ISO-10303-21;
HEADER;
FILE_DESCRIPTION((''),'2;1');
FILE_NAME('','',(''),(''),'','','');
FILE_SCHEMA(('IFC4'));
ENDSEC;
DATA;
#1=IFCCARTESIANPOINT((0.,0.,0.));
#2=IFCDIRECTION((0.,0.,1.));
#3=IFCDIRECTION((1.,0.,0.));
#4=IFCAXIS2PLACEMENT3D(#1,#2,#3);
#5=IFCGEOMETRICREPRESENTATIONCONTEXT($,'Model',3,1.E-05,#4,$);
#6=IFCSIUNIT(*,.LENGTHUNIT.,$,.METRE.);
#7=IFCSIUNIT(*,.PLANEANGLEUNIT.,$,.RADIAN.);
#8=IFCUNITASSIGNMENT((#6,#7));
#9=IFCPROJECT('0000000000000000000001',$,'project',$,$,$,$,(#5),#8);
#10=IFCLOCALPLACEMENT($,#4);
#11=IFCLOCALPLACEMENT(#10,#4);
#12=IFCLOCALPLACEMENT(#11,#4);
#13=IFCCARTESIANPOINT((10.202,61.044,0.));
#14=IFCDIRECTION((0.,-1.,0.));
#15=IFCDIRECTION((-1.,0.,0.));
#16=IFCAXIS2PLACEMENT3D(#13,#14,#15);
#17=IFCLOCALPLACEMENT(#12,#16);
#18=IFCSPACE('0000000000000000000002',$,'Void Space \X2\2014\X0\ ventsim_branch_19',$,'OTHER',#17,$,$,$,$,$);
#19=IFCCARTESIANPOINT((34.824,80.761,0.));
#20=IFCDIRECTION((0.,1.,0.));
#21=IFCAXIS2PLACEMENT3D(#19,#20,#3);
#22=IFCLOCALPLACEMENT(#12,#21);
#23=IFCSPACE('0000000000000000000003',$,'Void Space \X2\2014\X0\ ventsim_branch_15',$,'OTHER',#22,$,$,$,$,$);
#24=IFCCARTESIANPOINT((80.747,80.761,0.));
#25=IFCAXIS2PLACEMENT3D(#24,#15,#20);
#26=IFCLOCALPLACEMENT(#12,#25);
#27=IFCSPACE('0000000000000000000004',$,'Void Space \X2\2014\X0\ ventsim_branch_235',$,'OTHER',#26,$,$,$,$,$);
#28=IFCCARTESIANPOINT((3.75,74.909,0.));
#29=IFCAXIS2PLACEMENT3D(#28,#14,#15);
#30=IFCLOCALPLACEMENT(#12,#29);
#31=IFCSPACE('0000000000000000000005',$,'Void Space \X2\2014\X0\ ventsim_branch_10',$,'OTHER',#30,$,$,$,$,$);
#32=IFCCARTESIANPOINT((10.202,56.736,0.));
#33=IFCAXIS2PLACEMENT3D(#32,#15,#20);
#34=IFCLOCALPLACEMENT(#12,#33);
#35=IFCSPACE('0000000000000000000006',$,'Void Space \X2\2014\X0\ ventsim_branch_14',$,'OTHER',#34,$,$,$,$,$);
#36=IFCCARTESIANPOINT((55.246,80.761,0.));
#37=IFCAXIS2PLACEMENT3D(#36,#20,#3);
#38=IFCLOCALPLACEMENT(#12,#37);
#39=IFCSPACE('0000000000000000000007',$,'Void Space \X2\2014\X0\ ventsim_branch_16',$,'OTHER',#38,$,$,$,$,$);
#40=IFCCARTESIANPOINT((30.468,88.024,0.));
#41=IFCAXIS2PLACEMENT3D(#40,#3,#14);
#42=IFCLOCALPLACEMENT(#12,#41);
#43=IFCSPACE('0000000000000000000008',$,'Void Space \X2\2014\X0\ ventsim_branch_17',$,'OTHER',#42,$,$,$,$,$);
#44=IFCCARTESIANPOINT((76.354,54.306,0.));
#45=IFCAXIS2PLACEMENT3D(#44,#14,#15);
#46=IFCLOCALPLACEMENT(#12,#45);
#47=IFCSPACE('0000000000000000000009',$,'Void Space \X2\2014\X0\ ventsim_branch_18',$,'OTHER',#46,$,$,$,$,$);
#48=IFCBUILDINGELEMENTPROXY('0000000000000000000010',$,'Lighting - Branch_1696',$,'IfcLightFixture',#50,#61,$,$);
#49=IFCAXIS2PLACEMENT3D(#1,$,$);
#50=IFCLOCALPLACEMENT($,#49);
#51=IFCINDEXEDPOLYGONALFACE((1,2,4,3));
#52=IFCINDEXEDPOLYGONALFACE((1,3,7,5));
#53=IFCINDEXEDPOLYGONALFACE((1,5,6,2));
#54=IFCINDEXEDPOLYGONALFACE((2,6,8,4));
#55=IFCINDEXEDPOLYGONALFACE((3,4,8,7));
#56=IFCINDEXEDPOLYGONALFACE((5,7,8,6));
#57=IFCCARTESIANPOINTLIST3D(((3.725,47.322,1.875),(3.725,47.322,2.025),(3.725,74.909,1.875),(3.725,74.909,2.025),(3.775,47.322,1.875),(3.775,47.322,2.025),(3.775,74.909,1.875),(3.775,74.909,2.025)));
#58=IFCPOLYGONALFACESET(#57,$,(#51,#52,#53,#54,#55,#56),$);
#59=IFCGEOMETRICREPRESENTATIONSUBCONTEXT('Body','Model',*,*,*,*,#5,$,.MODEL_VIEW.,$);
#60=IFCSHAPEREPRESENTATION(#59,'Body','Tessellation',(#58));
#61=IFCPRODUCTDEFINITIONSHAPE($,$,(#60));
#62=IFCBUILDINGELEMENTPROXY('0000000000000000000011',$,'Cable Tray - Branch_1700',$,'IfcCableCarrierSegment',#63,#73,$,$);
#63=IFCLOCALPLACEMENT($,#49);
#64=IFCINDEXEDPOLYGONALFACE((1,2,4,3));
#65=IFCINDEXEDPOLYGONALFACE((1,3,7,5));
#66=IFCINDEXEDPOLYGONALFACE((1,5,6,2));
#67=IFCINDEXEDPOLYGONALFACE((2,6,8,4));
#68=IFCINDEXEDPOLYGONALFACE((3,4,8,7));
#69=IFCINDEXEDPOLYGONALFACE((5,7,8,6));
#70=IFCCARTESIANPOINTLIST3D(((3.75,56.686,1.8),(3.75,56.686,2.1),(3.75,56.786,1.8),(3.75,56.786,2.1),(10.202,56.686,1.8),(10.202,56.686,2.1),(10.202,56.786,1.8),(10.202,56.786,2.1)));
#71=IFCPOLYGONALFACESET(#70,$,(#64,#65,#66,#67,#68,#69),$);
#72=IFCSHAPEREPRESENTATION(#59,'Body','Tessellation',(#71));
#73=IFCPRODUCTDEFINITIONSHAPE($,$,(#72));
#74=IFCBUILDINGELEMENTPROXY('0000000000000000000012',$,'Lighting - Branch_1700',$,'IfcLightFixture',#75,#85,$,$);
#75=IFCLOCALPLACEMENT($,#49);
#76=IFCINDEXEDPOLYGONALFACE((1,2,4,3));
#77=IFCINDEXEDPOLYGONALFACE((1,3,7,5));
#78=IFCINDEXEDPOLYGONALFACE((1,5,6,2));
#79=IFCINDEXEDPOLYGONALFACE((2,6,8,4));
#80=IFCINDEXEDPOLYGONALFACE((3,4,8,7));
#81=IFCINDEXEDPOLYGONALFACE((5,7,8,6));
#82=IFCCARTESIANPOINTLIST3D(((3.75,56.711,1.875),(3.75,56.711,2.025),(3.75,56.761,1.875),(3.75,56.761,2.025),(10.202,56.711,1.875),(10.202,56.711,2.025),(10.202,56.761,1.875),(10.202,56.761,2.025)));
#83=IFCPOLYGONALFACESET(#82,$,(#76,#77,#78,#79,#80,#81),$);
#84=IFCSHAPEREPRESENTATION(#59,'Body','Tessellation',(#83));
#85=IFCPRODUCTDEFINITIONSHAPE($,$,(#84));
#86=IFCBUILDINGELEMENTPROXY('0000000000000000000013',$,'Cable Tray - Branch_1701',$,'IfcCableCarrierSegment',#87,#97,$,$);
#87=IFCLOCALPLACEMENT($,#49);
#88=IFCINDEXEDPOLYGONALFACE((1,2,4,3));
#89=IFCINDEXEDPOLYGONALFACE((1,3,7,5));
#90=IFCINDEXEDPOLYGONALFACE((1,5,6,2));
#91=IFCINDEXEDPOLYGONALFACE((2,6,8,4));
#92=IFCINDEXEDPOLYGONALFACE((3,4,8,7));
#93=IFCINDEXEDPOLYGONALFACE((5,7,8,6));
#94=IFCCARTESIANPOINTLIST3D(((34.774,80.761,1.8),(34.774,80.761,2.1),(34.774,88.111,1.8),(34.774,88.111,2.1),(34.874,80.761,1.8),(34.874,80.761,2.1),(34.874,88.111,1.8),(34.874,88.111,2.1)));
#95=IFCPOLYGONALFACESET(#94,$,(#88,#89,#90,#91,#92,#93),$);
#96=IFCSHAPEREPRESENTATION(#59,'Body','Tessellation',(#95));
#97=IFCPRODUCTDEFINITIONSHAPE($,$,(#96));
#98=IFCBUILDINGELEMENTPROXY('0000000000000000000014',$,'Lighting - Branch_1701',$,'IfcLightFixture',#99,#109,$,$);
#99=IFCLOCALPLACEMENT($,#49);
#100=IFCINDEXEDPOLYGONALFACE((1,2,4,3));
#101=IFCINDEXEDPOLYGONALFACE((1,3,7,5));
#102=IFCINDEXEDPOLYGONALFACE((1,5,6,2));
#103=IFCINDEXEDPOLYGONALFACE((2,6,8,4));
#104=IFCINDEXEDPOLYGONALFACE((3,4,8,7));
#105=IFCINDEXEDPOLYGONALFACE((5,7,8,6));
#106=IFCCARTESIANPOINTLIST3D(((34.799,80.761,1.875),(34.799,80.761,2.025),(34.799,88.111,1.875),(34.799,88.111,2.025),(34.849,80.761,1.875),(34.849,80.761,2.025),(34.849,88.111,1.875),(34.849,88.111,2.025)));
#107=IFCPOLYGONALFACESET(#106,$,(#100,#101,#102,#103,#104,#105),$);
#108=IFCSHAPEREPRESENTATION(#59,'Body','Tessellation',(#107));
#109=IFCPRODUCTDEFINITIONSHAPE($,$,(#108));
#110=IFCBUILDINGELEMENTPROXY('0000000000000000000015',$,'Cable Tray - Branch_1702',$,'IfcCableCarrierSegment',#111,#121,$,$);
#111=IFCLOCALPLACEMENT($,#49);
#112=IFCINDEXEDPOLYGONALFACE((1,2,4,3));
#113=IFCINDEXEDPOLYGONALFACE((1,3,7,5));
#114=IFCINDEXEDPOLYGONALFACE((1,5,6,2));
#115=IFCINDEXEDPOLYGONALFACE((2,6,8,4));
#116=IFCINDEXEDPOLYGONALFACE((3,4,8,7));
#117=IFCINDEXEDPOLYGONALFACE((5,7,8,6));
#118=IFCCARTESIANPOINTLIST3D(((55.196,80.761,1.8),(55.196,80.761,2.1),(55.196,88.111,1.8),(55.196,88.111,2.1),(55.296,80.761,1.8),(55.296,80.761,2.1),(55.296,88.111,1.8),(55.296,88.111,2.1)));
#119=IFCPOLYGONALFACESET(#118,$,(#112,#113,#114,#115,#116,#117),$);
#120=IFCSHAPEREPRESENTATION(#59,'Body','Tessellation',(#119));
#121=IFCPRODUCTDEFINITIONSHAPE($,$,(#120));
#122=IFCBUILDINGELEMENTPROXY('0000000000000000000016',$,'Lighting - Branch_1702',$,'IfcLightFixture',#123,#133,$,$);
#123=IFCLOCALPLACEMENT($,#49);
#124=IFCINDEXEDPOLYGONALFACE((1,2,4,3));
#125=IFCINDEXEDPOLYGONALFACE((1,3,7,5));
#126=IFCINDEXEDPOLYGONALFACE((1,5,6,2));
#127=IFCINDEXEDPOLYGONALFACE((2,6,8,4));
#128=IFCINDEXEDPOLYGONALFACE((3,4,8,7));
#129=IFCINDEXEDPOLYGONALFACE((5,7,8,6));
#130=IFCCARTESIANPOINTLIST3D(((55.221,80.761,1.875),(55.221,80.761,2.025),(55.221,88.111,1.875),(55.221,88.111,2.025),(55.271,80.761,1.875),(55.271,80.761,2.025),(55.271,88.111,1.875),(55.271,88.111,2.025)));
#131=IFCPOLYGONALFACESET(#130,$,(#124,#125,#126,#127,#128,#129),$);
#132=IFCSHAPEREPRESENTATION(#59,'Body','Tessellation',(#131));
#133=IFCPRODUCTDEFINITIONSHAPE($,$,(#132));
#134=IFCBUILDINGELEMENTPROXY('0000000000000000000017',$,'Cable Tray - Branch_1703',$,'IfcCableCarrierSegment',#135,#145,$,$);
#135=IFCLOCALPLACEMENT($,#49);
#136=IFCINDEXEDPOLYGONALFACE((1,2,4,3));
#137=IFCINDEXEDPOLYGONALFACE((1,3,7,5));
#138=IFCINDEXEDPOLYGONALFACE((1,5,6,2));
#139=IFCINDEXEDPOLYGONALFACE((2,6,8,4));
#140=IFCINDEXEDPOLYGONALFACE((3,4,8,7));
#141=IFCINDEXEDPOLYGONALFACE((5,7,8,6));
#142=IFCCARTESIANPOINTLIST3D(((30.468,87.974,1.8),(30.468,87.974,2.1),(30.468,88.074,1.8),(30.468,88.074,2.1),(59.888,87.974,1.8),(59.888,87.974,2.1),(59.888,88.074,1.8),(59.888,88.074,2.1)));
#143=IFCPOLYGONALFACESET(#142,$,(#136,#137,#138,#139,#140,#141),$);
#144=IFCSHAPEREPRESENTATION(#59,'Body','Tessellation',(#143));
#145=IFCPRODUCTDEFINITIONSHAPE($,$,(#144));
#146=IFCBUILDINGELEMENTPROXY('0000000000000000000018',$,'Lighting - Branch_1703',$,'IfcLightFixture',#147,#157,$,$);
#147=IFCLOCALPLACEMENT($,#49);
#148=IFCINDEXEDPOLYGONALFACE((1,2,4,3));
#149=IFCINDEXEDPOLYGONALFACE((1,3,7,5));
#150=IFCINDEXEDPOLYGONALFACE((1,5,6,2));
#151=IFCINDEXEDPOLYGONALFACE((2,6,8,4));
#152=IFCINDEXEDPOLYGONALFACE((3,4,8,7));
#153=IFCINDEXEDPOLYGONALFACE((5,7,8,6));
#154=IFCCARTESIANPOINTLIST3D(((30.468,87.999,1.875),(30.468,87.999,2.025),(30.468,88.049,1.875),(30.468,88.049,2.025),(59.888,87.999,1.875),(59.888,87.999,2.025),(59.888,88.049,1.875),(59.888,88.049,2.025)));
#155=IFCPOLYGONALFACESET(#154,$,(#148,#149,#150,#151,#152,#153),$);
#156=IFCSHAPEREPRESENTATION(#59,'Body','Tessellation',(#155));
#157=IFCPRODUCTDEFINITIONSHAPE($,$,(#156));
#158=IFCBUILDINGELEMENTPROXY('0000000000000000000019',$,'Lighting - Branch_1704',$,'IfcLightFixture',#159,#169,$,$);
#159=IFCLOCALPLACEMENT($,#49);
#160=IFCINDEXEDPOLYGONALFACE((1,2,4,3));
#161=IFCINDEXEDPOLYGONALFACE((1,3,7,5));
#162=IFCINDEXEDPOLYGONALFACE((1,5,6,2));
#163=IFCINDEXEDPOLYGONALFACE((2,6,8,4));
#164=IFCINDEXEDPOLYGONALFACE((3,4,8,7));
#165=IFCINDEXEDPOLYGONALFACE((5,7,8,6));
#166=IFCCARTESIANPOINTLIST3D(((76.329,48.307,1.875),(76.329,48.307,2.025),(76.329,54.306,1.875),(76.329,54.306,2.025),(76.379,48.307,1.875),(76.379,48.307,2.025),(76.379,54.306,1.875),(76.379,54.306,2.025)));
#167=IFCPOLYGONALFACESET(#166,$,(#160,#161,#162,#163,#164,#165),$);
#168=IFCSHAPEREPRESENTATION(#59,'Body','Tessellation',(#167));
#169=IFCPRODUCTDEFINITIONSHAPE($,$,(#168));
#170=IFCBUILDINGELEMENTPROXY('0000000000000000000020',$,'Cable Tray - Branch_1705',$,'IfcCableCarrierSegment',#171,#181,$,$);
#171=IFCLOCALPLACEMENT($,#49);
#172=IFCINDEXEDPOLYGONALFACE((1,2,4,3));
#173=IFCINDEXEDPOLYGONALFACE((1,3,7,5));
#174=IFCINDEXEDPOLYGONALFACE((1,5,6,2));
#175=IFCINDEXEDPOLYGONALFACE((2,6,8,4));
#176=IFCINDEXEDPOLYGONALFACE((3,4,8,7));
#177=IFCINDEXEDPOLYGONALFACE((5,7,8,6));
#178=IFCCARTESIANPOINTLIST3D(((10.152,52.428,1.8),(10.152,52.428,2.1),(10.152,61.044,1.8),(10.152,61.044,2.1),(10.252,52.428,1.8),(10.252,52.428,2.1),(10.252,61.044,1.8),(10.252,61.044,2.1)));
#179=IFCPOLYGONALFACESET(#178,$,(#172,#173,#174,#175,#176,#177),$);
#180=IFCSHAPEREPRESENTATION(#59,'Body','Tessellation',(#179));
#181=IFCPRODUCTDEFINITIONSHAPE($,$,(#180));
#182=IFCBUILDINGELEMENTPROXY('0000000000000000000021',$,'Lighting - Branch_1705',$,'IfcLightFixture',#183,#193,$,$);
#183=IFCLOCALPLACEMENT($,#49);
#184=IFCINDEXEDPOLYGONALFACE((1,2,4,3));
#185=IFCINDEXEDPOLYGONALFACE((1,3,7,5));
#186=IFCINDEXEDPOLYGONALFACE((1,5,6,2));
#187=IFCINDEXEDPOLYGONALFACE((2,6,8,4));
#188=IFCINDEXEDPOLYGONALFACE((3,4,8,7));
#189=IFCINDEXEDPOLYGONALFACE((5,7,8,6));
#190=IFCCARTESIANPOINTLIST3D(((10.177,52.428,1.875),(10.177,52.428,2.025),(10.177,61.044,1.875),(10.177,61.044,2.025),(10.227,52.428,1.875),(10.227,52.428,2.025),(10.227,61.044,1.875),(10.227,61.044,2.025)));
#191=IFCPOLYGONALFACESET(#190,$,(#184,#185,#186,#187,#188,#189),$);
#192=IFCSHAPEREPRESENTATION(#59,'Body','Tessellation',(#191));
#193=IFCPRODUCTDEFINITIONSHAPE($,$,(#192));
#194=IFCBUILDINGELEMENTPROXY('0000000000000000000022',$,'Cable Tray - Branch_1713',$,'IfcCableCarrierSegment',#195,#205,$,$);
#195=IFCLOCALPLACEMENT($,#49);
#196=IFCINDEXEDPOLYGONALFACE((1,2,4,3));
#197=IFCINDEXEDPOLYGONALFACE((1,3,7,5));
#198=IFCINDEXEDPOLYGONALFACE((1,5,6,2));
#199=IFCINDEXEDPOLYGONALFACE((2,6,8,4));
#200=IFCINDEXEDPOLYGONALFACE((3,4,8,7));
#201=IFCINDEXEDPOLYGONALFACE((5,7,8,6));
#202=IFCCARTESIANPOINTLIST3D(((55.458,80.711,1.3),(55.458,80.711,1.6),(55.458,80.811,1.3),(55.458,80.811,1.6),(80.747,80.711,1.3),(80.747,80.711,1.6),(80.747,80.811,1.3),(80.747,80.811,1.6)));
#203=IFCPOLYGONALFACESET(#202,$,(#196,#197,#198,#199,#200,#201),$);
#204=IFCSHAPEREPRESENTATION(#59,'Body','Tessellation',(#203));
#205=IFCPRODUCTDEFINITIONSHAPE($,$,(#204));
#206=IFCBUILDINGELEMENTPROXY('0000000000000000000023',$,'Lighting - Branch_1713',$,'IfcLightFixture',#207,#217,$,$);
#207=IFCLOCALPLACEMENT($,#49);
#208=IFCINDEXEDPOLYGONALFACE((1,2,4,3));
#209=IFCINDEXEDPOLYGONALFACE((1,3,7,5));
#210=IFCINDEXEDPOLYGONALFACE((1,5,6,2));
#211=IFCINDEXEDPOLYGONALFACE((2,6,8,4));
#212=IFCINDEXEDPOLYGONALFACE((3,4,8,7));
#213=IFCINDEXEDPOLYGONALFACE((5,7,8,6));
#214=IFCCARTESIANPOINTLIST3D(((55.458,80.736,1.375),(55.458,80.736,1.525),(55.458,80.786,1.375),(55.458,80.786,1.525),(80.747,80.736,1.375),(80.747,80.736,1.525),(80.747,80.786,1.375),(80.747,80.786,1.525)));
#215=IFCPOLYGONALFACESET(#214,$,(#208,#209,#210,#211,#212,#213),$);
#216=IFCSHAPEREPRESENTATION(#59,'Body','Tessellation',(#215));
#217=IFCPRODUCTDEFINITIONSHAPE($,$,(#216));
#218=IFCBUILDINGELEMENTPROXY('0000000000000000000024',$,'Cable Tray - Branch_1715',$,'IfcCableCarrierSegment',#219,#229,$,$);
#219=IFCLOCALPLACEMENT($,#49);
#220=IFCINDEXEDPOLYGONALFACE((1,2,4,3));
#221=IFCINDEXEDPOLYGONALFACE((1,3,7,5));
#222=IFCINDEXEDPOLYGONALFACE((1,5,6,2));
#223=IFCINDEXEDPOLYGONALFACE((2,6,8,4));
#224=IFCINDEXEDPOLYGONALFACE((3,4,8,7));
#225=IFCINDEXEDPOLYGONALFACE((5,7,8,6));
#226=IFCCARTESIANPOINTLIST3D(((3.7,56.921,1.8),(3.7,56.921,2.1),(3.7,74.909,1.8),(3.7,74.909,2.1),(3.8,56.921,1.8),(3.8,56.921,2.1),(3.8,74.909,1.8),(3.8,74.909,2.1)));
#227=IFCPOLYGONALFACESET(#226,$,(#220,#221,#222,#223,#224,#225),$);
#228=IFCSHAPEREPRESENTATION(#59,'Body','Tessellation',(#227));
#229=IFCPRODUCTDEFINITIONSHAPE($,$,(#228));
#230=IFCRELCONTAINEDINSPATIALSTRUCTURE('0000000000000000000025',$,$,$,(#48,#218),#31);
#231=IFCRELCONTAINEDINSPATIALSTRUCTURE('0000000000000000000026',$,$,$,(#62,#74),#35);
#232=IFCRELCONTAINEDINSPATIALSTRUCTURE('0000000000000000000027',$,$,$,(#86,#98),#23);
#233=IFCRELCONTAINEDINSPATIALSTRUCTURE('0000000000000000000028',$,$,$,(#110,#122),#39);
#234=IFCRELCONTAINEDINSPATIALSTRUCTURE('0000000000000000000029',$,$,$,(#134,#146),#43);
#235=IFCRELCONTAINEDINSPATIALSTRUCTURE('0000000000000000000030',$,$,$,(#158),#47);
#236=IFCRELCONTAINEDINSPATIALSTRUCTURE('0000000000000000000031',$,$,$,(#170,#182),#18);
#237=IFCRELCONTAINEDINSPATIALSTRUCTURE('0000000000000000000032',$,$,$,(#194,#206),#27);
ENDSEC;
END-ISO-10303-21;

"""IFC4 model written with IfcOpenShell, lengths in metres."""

from ifc_helpers import new_model, si_unit, frame, origin_with_axes, origin_2d_with_axis, place, context, subcontext, project, spatial, rectangle, extrude, element, save


model = new_model("IFC4")

# Units and contexts
model_context = context("Model", 3, precision=1e-05, world=origin_with_axes())
body_context = subcontext(model_context, "Body", "Model", "MODEL_VIEW")
ifc_project = project(units=[si_unit("LENGTHUNIT", "METRE"), si_unit("PLANEANGLEUNIT", "RADIAN")], contexts=[model_context])

# Space
placement_1 = place(None, origin_with_axes())
placement_2 = place(placement_1, origin_with_axes())
placement_3 = place(placement_2, origin_with_axes())
space_1_placement = place(placement_3, frame((10.202, 61.044, 0.0), z_axis=(0.0, -1.0, 0.0), x_axis=(-1.0, 0.0, 0.0)))
space_1 = spatial("IfcSpace", at=space_1_placement, Name="Void Space — ventsim_branch_19", ObjectType="OTHER")

# Shared definitions
space_2_placement = place(placement_3, frame((34.824, 80.761, 0.0), z_axis=(0.0, 1.0, 0.0), x_axis=(1.0, 0.0, 0.0)))
space_2 = spatial("IfcSpace", at=space_2_placement, Name="Void Space — ventsim_branch_15", ObjectType="OTHER")

# Shared definitions
space_3_placement = place(placement_3, frame((80.747, 80.761, 0.0), z_axis=(-1.0, 0.0, 0.0), x_axis=(0.0, 1.0, 0.0)))
space_3 = spatial("IfcSpace", at=space_3_placement, Name="Void Space — ventsim_branch_235", ObjectType="OTHER")

# Shared definitions
space_4_placement = place(placement_3, frame((3.75, 74.909, 0.0), z_axis=(0.0, -1.0, 0.0), x_axis=(-1.0, 0.0, 0.0)))
space_4 = spatial("IfcSpace", at=space_4_placement, Name="Void Space — ventsim_branch_10", ObjectType="OTHER")

# Building element proxy
proxy_1_placement = place(placement_3, frame((3.75, 74.909, 1.95), z_axis=(0.0, -1.0, 0.0), x_axis=(0.0, 0.0, 1.0)))
element("IfcBuildingElementProxy", 1, at=proxy_1_placement, inside=space_4, Name="Lighting - Branch_1696", ObjectType="IfcLightFixture", context=body_context, shape_type="SweptSolid", body=[
    extrude(rectangle(XDim=0.15, YDim=0.05, at=origin_2d_with_axis()), origin_with_axes(), (0.0, 0.0, 1.0), 27.587),
])

# Shared definitions
space_5_placement = place(placement_3, frame((10.202, 56.736, 0.0), z_axis=(-1.0, 0.0, 0.0), x_axis=(0.0, 1.0, 0.0)))
space_5 = spatial("IfcSpace", at=space_5_placement, Name="Void Space — ventsim_branch_14", ObjectType="OTHER")

# Building element proxies
proxy_2_placement = place(placement_3, frame((10.202, 56.736, 1.95), z_axis=(-1.0, 0.0, 0.0), x_axis=(0.0, 0.0, 1.0)))
element("IfcBuildingElementProxy", 2, at=proxy_2_placement, inside=space_5, Name="Cable Tray - Branch_1700", ObjectType="IfcCableCarrierSegment", context=body_context, shape_type="SweptSolid", body=[
    extrude(rectangle(XDim=0.3, YDim=0.1, at=origin_2d_with_axis()), origin_with_axes(), (0.0, 0.0, 1.0), 6.452),
])
proxy_3_placement = place(placement_3, frame((10.202, 56.736, 1.95), z_axis=(-1.0, 0.0, 0.0), x_axis=(0.0, 0.0, 1.0)))
element("IfcBuildingElementProxy", 3, at=proxy_3_placement, inside=space_5, Name="Lighting - Branch_1700", ObjectType="IfcLightFixture", context=body_context, shape_type="SweptSolid", body=[
    extrude(rectangle(XDim=0.15, YDim=0.05, at=origin_2d_with_axis()), origin_with_axes(), (0.0, 0.0, 1.0), 6.452),
])
proxy_4_placement = place(placement_3, frame((34.824, 80.761, 1.95), z_axis=(0.0, 1.0, 0.0), x_axis=(0.0, 0.0, 1.0)))
element("IfcBuildingElementProxy", 4, at=proxy_4_placement, inside=space_2, Name="Cable Tray - Branch_1701", ObjectType="IfcCableCarrierSegment", context=body_context, shape_type="SweptSolid", body=[
    extrude(rectangle(XDim=0.3, YDim=0.1, at=origin_2d_with_axis()), origin_with_axes(), (0.0, 0.0, 1.0), 7.35),
])
proxy_5_placement = place(placement_3, frame((34.824, 80.761, 1.95), z_axis=(0.0, 1.0, 0.0), x_axis=(0.0, 0.0, 1.0)))
element("IfcBuildingElementProxy", 5, at=proxy_5_placement, inside=space_2, Name="Lighting - Branch_1701", ObjectType="IfcLightFixture", context=body_context, shape_type="SweptSolid", body=[
    extrude(rectangle(XDim=0.15, YDim=0.05, at=origin_2d_with_axis()), origin_with_axes(), (0.0, 0.0, 1.0), 7.35),
])

# Shared definitions
space_6_placement = place(placement_3, frame((55.246, 80.761, 0.0), z_axis=(0.0, 1.0, 0.0), x_axis=(1.0, 0.0, 0.0)))
space_6 = spatial("IfcSpace", at=space_6_placement, Name="Void Space — ventsim_branch_16", ObjectType="OTHER")

# Building element proxies
proxy_6_placement = place(placement_3, frame((55.246, 80.761, 1.95), z_axis=(0.0, 1.0, 0.0), x_axis=(0.0, 0.0, 1.0)))
element("IfcBuildingElementProxy", 6, at=proxy_6_placement, inside=space_6, Name="Cable Tray - Branch_1702", ObjectType="IfcCableCarrierSegment", context=body_context, shape_type="SweptSolid", body=[
    extrude(rectangle(XDim=0.3, YDim=0.1, at=origin_2d_with_axis()), origin_with_axes(), (0.0, 0.0, 1.0), 7.35),
])
proxy_7_placement = place(placement_3, frame((55.246, 80.761, 1.95), z_axis=(0.0, 1.0, 0.0), x_axis=(0.0, 0.0, 1.0)))
element("IfcBuildingElementProxy", 7, at=proxy_7_placement, inside=space_6, Name="Lighting - Branch_1702", ObjectType="IfcLightFixture", context=body_context, shape_type="SweptSolid", body=[
    extrude(rectangle(XDim=0.15, YDim=0.05, at=origin_2d_with_axis()), origin_with_axes(), (0.0, 0.0, 1.0), 7.35),
])

# Shared definitions
space_7_placement = place(placement_3, frame((30.468, 88.024, 0.0), z_axis=(1.0, 0.0, 0.0), x_axis=(0.0, -1.0, 0.0)))
space_7 = spatial("IfcSpace", at=space_7_placement, Name="Void Space — ventsim_branch_17", ObjectType="OTHER")

# Building element proxies
proxy_8_placement = place(placement_3, frame((30.468, 88.024, 1.95), z_axis=(1.0, 0.0, 0.0), x_axis=(0.0, 0.0, 1.0)))
element("IfcBuildingElementProxy", 8, at=proxy_8_placement, inside=space_7, Name="Cable Tray - Branch_1703", ObjectType="IfcCableCarrierSegment", context=body_context, shape_type="SweptSolid", body=[
    extrude(rectangle(XDim=0.3, YDim=0.1, at=origin_2d_with_axis()), origin_with_axes(), (0.0, 0.0, 1.0), 29.42),
])
proxy_9_placement = place(placement_3, frame((30.468, 88.024, 1.95), z_axis=(1.0, 0.0, 0.0), x_axis=(0.0, 0.0, 1.0)))
element("IfcBuildingElementProxy", 9, at=proxy_9_placement, inside=space_7, Name="Lighting - Branch_1703", ObjectType="IfcLightFixture", context=body_context, shape_type="SweptSolid", body=[
    extrude(rectangle(XDim=0.15, YDim=0.05, at=origin_2d_with_axis()), origin_with_axes(), (0.0, 0.0, 1.0), 29.42),
])

# Shared definitions
space_8_placement = place(placement_3, frame((76.354, 54.306, 0.0), z_axis=(0.0, -1.0, 0.0), x_axis=(-1.0, 0.0, 0.0)))
space_8 = spatial("IfcSpace", at=space_8_placement, Name="Void Space — ventsim_branch_18", ObjectType="OTHER")

# Building element proxies
proxy_10_placement = place(placement_3, frame((76.354, 54.306, 1.95), z_axis=(0.0, -1.0, 0.0), x_axis=(0.0, 0.0, 1.0)))
element("IfcBuildingElementProxy", 10, at=proxy_10_placement, inside=space_8, Name="Lighting - Branch_1704", ObjectType="IfcLightFixture", context=body_context, shape_type="SweptSolid", body=[
    extrude(rectangle(XDim=0.15, YDim=0.05, at=origin_2d_with_axis()), origin_with_axes(), (0.0, 0.0, 1.0), 5.999),
])
proxy_11_placement = place(placement_3, frame((10.202, 61.044, 1.95), z_axis=(0.0, -1.0, 0.0), x_axis=(0.0, 0.0, 1.0)))
element("IfcBuildingElementProxy", 11, at=proxy_11_placement, inside=space_1, Name="Cable Tray - Branch_1705", ObjectType="IfcCableCarrierSegment", context=body_context, shape_type="SweptSolid", body=[
    extrude(rectangle(XDim=0.3, YDim=0.1, at=origin_2d_with_axis()), origin_with_axes(), (0.0, 0.0, 1.0), 8.616),
])
proxy_12_placement = place(placement_3, frame((10.202, 61.044, 1.95), z_axis=(0.0, -1.0, 0.0), x_axis=(0.0, 0.0, 1.0)))
element("IfcBuildingElementProxy", 12, at=proxy_12_placement, inside=space_1, Name="Lighting - Branch_1705", ObjectType="IfcLightFixture", context=body_context, shape_type="SweptSolid", body=[
    extrude(rectangle(XDim=0.15, YDim=0.05, at=origin_2d_with_axis()), origin_with_axes(), (0.0, 0.0, 1.0), 8.616),
])
proxy_13_placement = place(placement_3, frame((80.747, 80.761, 1.45), z_axis=(-1.0, 0.0, 0.0), x_axis=(0.0, 0.0, 1.0)))
element("IfcBuildingElementProxy", 13, at=proxy_13_placement, inside=space_3, Name="Cable Tray - Branch_1713", ObjectType="IfcCableCarrierSegment", context=body_context, shape_type="SweptSolid", body=[
    extrude(rectangle(XDim=0.3, YDim=0.1, at=origin_2d_with_axis()), origin_with_axes(), (0.0, 0.0, 1.0), 25.289),
])
proxy_14_placement = place(placement_3, frame((80.747, 80.761, 1.45), z_axis=(-1.0, 0.0, 0.0), x_axis=(0.0, 0.0, 1.0)))
element("IfcBuildingElementProxy", 14, at=proxy_14_placement, inside=space_3, Name="Lighting - Branch_1713", ObjectType="IfcLightFixture", context=body_context, shape_type="SweptSolid", body=[
    extrude(rectangle(XDim=0.15, YDim=0.05, at=origin_2d_with_axis()), origin_with_axes(), (0.0, 0.0, 1.0), 25.289),
])
proxy_15_placement = place(placement_3, frame((3.75, 74.909, 1.95), z_axis=(0.0, -1.0, 0.0), x_axis=(0.0, 0.0, 1.0)))
element("IfcBuildingElementProxy", 15, at=proxy_15_placement, inside=space_4, Name="Cable Tray - Branch_1715", ObjectType="IfcCableCarrierSegment", context=body_context, shape_type="SweptSolid", body=[
    extrude(rectangle(XDim=0.3, YDim=0.1, at=origin_2d_with_axis()), origin_with_axes(), (0.0, 0.0, 1.0), 17.988),
])

save(model, "model.ifc")
